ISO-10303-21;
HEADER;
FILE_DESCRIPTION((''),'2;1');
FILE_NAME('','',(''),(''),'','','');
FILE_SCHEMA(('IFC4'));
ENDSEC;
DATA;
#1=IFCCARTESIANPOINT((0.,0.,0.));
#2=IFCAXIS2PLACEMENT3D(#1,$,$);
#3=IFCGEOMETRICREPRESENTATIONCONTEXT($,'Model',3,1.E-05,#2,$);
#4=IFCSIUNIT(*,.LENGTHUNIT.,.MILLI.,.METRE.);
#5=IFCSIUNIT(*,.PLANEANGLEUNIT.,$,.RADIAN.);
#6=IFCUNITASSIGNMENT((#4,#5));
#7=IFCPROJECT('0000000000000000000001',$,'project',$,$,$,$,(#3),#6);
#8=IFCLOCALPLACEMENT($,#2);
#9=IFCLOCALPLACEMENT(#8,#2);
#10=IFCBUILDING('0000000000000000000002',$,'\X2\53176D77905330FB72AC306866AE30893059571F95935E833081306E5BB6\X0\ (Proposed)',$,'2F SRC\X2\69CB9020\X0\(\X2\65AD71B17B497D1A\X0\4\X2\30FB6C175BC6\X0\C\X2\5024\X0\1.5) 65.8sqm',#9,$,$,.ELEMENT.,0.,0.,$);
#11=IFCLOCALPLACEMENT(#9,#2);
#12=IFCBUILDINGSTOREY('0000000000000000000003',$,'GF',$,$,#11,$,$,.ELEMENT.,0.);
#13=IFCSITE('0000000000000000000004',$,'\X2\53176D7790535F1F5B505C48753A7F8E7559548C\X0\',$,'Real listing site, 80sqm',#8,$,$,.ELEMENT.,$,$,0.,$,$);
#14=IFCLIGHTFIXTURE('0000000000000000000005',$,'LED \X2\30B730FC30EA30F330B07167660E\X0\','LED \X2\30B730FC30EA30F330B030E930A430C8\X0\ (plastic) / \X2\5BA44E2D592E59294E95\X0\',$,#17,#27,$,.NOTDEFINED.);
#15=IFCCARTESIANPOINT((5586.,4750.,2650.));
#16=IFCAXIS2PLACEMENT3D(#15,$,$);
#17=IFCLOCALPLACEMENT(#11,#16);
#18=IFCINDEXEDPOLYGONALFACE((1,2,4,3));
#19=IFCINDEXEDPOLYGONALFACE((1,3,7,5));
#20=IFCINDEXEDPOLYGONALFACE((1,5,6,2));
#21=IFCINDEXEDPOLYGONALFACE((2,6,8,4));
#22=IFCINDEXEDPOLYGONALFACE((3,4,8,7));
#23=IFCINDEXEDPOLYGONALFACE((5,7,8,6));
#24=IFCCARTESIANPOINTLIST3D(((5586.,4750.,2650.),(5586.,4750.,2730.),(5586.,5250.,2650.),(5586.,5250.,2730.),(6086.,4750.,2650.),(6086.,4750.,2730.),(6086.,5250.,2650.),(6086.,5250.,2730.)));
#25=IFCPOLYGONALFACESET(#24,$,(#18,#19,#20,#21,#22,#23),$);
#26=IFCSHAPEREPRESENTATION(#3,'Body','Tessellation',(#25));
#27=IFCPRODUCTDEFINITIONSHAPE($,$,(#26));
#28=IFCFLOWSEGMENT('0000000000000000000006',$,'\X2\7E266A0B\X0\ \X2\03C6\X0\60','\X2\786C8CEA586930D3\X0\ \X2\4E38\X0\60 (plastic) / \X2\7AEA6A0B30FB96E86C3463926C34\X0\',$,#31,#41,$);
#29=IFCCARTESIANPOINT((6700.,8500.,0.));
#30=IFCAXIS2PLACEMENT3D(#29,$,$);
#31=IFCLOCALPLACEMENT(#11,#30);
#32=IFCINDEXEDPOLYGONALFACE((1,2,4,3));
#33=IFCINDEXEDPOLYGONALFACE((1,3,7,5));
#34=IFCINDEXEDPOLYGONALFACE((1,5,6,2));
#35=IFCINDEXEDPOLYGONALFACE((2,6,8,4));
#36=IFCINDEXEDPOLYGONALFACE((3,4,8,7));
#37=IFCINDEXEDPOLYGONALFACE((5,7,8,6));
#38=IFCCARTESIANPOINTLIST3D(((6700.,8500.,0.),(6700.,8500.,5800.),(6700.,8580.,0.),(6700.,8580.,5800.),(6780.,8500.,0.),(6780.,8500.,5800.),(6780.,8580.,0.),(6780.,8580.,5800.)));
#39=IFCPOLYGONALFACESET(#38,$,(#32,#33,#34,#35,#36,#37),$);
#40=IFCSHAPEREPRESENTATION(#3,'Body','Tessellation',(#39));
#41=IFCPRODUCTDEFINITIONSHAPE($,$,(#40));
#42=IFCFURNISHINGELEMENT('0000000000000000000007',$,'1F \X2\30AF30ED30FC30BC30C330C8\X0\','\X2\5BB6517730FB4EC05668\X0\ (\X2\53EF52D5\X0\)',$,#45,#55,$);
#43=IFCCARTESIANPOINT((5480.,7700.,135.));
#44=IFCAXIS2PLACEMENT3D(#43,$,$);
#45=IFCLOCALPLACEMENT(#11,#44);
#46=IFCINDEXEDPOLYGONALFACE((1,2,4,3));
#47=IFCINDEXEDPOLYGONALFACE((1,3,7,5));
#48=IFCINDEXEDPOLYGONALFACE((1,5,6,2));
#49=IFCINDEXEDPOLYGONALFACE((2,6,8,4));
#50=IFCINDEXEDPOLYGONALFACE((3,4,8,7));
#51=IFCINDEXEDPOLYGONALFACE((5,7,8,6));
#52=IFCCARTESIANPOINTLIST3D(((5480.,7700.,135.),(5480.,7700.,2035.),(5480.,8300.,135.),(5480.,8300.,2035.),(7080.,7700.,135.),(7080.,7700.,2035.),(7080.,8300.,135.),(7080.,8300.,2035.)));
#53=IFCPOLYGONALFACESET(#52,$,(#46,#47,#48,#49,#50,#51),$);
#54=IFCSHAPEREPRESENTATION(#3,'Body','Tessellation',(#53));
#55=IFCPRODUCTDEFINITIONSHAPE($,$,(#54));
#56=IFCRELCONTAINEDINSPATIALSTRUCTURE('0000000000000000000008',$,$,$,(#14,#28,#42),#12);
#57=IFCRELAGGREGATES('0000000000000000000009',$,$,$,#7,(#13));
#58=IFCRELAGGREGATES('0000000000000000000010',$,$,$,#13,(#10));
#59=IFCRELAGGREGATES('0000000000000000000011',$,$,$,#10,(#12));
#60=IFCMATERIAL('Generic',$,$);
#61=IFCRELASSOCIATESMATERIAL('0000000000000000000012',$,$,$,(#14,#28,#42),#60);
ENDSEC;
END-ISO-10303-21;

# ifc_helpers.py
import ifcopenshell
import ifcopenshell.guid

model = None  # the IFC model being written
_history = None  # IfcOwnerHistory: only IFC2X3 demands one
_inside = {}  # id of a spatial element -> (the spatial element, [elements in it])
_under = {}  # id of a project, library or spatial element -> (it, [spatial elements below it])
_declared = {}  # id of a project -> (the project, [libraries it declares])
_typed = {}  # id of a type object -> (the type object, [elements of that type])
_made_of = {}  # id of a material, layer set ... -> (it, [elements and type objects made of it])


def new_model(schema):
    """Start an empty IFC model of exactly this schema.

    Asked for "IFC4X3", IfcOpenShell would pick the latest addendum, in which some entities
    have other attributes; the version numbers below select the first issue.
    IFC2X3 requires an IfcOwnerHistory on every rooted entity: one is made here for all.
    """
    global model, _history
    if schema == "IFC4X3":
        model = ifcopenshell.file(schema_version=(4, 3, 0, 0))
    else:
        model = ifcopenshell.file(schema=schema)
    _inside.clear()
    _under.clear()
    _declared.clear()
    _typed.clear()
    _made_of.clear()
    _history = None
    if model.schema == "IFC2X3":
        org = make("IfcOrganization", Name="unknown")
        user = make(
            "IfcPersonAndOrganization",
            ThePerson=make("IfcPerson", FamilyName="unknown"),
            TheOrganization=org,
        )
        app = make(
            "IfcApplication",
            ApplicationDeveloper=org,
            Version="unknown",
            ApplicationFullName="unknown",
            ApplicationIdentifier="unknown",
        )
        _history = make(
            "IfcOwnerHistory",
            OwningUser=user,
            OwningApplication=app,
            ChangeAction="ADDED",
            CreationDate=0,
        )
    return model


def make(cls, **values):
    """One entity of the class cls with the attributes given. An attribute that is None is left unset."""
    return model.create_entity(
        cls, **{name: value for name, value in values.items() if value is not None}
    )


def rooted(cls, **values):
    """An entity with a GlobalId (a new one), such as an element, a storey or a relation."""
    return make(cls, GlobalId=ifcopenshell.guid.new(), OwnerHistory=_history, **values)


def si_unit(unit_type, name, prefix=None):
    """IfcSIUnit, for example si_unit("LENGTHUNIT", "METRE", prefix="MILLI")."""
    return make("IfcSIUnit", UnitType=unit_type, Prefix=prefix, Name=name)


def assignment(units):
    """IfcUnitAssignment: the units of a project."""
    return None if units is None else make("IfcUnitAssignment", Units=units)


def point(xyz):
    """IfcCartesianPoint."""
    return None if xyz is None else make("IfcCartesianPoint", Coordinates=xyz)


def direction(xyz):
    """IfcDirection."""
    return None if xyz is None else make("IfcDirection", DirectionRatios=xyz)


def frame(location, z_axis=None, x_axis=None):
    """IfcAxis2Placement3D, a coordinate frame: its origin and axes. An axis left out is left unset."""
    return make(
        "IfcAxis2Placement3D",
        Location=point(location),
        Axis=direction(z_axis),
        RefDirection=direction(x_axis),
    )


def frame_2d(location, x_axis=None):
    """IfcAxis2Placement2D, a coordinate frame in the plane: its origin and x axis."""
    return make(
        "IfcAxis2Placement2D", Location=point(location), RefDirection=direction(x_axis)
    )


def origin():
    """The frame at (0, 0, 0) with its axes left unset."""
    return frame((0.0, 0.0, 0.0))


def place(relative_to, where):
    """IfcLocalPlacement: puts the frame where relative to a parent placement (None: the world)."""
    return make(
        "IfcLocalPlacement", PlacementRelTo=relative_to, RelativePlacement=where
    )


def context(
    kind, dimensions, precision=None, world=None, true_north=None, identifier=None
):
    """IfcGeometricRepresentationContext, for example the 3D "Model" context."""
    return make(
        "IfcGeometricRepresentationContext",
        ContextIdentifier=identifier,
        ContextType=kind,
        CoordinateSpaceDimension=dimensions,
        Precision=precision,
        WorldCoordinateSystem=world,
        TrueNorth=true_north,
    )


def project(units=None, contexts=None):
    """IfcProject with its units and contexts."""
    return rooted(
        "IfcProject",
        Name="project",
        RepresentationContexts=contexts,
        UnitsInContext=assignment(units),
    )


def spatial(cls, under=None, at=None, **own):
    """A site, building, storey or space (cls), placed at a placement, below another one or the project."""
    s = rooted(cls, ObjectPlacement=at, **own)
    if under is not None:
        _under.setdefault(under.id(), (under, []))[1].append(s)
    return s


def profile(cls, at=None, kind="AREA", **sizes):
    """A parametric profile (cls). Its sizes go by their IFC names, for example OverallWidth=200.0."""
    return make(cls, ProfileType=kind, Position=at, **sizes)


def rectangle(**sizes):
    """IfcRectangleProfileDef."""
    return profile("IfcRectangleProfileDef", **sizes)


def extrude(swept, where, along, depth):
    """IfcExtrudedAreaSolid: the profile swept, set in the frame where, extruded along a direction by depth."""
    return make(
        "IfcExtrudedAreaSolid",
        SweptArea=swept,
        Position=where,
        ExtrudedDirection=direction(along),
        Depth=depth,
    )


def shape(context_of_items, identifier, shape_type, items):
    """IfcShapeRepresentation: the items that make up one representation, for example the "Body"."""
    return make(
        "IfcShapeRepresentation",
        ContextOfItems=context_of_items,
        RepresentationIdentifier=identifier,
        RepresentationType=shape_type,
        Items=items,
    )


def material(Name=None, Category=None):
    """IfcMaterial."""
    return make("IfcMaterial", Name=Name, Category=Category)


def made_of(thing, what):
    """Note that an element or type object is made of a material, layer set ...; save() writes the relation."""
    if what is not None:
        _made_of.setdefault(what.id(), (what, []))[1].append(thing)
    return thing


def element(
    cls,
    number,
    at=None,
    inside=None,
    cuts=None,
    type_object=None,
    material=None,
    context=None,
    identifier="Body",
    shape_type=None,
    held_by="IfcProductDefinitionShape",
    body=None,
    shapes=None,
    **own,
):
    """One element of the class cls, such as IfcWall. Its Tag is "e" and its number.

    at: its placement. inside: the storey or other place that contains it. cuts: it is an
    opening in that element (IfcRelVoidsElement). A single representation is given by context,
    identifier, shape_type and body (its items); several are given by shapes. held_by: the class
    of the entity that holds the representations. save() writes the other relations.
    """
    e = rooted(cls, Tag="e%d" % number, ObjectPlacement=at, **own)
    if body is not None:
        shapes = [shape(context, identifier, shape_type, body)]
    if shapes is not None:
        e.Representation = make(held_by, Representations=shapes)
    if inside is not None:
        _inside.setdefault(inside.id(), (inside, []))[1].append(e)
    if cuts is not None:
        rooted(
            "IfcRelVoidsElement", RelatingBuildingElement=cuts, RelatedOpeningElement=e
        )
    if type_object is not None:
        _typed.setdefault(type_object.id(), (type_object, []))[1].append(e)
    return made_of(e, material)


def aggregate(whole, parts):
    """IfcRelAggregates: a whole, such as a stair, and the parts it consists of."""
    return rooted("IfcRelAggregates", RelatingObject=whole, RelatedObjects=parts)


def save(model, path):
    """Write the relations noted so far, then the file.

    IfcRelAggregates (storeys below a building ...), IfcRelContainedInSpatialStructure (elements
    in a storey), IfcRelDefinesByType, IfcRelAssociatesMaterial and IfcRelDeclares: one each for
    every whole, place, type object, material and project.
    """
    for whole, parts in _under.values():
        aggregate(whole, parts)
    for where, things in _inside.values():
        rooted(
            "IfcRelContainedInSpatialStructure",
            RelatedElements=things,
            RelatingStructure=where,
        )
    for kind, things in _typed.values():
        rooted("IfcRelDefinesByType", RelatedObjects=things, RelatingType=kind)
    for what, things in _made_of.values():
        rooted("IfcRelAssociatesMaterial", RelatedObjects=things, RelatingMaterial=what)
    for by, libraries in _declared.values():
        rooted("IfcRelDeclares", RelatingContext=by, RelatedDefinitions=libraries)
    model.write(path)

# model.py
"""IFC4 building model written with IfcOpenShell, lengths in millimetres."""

from ifc_helpers import new_model, si_unit, frame, frame_2d, origin, place, context, project, spatial, rectangle, extrude, material, element, save


model = new_model("IFC4")

# Units and contexts
model_context = context("Model", 3, precision=1e-05, world=origin())
ifc_project = project(units=[si_unit("LENGTHUNIT", "METRE", prefix="MILLI"), si_unit("PLANEANGLEUNIT", "RADIAN")], contexts=[model_context])

# Site, building, storey
site_placement = place(None, origin())
site = spatial("IfcSite", under=ifc_project, at=site_placement, Name="北海道弟子屈町美留和", ObjectType="Real listing site, 80sqm", CompositionType="ELEMENT", RefElevation=0.0)
building_placement = place(site_placement, origin())
building = spatial("IfcBuilding", under=site, at=building_placement, Name="北海道・犬と暮らす土間広めの家 (Proposed)", ObjectType="2F SRC構造(断熱等級4・気密C値1.5) 65.8sqm", CompositionType="ELEMENT", ElevationOfRefHeight=0.0, ElevationOfTerrain=0.0)
storey_placement = place(building_placement, origin())
storey = spatial("IfcBuildingStorey", under=building, at=storey_placement, Name="GF", CompositionType="ELEMENT", Elevation=0.0)

# Shared definitions
ifc_material_1 = material(Name="Generic")

# Light fixture
light_fixture_placement = place(storey_placement, frame((5586.0, 4750.0, 2650.0)))
element("IfcLightFixture", 1, at=light_fixture_placement, inside=storey, material=ifc_material_1, Name="LED シーリング照明", Description="LED シーリングライト (plastic) / 室中央天井", PredefinedType="NOTDEFINED", context=model_context, shape_type="SweptSolid", body=[
    extrude(rectangle(XDim=500.0, YDim=500.0, at=frame_2d((250.0, 250.0))), frame((5586.0, 4750.0, 2650.0)), (0.0, 0.0, 1.0), 80.0),
])

# Flow segment
flow_segment_placement = place(storey_placement, frame((6700.0, 8500.0, 0.0)))
element("IfcFlowSegment", 2, at=flow_segment_placement, inside=storey, material=ifc_material_1, Name="縦樋 φ60", Description="硬質塩ビ 丸60 (plastic) / 竪樋・雨水排水", context=model_context, shape_type="SweptSolid", body=[
    extrude(rectangle(XDim=80.0, YDim=80.0, at=frame_2d((40.0, 40.0))), frame((6700.0, 8500.0, 0.0)), (0.0, 0.0, 1.0), 5800.0),
])

# Furnishing element
furnishing_placement = place(storey_placement, frame((5480.0, 7700.0, 135.0)))
element("IfcFurnishingElement", 3, at=furnishing_placement, inside=storey, material=ifc_material_1, Name="1F クローゼット", Description="家具・什器 (可動)", context=model_context, shape_type="SweptSolid", body=[
    extrude(rectangle(XDim=1600.0, YDim=600.0, at=frame_2d((800.0, 300.0))), frame((5480.0, 7700.0, 135.0)), (0.0, 0.0, 1.0), 1900.0),
])

save(model, "model.ifc")
